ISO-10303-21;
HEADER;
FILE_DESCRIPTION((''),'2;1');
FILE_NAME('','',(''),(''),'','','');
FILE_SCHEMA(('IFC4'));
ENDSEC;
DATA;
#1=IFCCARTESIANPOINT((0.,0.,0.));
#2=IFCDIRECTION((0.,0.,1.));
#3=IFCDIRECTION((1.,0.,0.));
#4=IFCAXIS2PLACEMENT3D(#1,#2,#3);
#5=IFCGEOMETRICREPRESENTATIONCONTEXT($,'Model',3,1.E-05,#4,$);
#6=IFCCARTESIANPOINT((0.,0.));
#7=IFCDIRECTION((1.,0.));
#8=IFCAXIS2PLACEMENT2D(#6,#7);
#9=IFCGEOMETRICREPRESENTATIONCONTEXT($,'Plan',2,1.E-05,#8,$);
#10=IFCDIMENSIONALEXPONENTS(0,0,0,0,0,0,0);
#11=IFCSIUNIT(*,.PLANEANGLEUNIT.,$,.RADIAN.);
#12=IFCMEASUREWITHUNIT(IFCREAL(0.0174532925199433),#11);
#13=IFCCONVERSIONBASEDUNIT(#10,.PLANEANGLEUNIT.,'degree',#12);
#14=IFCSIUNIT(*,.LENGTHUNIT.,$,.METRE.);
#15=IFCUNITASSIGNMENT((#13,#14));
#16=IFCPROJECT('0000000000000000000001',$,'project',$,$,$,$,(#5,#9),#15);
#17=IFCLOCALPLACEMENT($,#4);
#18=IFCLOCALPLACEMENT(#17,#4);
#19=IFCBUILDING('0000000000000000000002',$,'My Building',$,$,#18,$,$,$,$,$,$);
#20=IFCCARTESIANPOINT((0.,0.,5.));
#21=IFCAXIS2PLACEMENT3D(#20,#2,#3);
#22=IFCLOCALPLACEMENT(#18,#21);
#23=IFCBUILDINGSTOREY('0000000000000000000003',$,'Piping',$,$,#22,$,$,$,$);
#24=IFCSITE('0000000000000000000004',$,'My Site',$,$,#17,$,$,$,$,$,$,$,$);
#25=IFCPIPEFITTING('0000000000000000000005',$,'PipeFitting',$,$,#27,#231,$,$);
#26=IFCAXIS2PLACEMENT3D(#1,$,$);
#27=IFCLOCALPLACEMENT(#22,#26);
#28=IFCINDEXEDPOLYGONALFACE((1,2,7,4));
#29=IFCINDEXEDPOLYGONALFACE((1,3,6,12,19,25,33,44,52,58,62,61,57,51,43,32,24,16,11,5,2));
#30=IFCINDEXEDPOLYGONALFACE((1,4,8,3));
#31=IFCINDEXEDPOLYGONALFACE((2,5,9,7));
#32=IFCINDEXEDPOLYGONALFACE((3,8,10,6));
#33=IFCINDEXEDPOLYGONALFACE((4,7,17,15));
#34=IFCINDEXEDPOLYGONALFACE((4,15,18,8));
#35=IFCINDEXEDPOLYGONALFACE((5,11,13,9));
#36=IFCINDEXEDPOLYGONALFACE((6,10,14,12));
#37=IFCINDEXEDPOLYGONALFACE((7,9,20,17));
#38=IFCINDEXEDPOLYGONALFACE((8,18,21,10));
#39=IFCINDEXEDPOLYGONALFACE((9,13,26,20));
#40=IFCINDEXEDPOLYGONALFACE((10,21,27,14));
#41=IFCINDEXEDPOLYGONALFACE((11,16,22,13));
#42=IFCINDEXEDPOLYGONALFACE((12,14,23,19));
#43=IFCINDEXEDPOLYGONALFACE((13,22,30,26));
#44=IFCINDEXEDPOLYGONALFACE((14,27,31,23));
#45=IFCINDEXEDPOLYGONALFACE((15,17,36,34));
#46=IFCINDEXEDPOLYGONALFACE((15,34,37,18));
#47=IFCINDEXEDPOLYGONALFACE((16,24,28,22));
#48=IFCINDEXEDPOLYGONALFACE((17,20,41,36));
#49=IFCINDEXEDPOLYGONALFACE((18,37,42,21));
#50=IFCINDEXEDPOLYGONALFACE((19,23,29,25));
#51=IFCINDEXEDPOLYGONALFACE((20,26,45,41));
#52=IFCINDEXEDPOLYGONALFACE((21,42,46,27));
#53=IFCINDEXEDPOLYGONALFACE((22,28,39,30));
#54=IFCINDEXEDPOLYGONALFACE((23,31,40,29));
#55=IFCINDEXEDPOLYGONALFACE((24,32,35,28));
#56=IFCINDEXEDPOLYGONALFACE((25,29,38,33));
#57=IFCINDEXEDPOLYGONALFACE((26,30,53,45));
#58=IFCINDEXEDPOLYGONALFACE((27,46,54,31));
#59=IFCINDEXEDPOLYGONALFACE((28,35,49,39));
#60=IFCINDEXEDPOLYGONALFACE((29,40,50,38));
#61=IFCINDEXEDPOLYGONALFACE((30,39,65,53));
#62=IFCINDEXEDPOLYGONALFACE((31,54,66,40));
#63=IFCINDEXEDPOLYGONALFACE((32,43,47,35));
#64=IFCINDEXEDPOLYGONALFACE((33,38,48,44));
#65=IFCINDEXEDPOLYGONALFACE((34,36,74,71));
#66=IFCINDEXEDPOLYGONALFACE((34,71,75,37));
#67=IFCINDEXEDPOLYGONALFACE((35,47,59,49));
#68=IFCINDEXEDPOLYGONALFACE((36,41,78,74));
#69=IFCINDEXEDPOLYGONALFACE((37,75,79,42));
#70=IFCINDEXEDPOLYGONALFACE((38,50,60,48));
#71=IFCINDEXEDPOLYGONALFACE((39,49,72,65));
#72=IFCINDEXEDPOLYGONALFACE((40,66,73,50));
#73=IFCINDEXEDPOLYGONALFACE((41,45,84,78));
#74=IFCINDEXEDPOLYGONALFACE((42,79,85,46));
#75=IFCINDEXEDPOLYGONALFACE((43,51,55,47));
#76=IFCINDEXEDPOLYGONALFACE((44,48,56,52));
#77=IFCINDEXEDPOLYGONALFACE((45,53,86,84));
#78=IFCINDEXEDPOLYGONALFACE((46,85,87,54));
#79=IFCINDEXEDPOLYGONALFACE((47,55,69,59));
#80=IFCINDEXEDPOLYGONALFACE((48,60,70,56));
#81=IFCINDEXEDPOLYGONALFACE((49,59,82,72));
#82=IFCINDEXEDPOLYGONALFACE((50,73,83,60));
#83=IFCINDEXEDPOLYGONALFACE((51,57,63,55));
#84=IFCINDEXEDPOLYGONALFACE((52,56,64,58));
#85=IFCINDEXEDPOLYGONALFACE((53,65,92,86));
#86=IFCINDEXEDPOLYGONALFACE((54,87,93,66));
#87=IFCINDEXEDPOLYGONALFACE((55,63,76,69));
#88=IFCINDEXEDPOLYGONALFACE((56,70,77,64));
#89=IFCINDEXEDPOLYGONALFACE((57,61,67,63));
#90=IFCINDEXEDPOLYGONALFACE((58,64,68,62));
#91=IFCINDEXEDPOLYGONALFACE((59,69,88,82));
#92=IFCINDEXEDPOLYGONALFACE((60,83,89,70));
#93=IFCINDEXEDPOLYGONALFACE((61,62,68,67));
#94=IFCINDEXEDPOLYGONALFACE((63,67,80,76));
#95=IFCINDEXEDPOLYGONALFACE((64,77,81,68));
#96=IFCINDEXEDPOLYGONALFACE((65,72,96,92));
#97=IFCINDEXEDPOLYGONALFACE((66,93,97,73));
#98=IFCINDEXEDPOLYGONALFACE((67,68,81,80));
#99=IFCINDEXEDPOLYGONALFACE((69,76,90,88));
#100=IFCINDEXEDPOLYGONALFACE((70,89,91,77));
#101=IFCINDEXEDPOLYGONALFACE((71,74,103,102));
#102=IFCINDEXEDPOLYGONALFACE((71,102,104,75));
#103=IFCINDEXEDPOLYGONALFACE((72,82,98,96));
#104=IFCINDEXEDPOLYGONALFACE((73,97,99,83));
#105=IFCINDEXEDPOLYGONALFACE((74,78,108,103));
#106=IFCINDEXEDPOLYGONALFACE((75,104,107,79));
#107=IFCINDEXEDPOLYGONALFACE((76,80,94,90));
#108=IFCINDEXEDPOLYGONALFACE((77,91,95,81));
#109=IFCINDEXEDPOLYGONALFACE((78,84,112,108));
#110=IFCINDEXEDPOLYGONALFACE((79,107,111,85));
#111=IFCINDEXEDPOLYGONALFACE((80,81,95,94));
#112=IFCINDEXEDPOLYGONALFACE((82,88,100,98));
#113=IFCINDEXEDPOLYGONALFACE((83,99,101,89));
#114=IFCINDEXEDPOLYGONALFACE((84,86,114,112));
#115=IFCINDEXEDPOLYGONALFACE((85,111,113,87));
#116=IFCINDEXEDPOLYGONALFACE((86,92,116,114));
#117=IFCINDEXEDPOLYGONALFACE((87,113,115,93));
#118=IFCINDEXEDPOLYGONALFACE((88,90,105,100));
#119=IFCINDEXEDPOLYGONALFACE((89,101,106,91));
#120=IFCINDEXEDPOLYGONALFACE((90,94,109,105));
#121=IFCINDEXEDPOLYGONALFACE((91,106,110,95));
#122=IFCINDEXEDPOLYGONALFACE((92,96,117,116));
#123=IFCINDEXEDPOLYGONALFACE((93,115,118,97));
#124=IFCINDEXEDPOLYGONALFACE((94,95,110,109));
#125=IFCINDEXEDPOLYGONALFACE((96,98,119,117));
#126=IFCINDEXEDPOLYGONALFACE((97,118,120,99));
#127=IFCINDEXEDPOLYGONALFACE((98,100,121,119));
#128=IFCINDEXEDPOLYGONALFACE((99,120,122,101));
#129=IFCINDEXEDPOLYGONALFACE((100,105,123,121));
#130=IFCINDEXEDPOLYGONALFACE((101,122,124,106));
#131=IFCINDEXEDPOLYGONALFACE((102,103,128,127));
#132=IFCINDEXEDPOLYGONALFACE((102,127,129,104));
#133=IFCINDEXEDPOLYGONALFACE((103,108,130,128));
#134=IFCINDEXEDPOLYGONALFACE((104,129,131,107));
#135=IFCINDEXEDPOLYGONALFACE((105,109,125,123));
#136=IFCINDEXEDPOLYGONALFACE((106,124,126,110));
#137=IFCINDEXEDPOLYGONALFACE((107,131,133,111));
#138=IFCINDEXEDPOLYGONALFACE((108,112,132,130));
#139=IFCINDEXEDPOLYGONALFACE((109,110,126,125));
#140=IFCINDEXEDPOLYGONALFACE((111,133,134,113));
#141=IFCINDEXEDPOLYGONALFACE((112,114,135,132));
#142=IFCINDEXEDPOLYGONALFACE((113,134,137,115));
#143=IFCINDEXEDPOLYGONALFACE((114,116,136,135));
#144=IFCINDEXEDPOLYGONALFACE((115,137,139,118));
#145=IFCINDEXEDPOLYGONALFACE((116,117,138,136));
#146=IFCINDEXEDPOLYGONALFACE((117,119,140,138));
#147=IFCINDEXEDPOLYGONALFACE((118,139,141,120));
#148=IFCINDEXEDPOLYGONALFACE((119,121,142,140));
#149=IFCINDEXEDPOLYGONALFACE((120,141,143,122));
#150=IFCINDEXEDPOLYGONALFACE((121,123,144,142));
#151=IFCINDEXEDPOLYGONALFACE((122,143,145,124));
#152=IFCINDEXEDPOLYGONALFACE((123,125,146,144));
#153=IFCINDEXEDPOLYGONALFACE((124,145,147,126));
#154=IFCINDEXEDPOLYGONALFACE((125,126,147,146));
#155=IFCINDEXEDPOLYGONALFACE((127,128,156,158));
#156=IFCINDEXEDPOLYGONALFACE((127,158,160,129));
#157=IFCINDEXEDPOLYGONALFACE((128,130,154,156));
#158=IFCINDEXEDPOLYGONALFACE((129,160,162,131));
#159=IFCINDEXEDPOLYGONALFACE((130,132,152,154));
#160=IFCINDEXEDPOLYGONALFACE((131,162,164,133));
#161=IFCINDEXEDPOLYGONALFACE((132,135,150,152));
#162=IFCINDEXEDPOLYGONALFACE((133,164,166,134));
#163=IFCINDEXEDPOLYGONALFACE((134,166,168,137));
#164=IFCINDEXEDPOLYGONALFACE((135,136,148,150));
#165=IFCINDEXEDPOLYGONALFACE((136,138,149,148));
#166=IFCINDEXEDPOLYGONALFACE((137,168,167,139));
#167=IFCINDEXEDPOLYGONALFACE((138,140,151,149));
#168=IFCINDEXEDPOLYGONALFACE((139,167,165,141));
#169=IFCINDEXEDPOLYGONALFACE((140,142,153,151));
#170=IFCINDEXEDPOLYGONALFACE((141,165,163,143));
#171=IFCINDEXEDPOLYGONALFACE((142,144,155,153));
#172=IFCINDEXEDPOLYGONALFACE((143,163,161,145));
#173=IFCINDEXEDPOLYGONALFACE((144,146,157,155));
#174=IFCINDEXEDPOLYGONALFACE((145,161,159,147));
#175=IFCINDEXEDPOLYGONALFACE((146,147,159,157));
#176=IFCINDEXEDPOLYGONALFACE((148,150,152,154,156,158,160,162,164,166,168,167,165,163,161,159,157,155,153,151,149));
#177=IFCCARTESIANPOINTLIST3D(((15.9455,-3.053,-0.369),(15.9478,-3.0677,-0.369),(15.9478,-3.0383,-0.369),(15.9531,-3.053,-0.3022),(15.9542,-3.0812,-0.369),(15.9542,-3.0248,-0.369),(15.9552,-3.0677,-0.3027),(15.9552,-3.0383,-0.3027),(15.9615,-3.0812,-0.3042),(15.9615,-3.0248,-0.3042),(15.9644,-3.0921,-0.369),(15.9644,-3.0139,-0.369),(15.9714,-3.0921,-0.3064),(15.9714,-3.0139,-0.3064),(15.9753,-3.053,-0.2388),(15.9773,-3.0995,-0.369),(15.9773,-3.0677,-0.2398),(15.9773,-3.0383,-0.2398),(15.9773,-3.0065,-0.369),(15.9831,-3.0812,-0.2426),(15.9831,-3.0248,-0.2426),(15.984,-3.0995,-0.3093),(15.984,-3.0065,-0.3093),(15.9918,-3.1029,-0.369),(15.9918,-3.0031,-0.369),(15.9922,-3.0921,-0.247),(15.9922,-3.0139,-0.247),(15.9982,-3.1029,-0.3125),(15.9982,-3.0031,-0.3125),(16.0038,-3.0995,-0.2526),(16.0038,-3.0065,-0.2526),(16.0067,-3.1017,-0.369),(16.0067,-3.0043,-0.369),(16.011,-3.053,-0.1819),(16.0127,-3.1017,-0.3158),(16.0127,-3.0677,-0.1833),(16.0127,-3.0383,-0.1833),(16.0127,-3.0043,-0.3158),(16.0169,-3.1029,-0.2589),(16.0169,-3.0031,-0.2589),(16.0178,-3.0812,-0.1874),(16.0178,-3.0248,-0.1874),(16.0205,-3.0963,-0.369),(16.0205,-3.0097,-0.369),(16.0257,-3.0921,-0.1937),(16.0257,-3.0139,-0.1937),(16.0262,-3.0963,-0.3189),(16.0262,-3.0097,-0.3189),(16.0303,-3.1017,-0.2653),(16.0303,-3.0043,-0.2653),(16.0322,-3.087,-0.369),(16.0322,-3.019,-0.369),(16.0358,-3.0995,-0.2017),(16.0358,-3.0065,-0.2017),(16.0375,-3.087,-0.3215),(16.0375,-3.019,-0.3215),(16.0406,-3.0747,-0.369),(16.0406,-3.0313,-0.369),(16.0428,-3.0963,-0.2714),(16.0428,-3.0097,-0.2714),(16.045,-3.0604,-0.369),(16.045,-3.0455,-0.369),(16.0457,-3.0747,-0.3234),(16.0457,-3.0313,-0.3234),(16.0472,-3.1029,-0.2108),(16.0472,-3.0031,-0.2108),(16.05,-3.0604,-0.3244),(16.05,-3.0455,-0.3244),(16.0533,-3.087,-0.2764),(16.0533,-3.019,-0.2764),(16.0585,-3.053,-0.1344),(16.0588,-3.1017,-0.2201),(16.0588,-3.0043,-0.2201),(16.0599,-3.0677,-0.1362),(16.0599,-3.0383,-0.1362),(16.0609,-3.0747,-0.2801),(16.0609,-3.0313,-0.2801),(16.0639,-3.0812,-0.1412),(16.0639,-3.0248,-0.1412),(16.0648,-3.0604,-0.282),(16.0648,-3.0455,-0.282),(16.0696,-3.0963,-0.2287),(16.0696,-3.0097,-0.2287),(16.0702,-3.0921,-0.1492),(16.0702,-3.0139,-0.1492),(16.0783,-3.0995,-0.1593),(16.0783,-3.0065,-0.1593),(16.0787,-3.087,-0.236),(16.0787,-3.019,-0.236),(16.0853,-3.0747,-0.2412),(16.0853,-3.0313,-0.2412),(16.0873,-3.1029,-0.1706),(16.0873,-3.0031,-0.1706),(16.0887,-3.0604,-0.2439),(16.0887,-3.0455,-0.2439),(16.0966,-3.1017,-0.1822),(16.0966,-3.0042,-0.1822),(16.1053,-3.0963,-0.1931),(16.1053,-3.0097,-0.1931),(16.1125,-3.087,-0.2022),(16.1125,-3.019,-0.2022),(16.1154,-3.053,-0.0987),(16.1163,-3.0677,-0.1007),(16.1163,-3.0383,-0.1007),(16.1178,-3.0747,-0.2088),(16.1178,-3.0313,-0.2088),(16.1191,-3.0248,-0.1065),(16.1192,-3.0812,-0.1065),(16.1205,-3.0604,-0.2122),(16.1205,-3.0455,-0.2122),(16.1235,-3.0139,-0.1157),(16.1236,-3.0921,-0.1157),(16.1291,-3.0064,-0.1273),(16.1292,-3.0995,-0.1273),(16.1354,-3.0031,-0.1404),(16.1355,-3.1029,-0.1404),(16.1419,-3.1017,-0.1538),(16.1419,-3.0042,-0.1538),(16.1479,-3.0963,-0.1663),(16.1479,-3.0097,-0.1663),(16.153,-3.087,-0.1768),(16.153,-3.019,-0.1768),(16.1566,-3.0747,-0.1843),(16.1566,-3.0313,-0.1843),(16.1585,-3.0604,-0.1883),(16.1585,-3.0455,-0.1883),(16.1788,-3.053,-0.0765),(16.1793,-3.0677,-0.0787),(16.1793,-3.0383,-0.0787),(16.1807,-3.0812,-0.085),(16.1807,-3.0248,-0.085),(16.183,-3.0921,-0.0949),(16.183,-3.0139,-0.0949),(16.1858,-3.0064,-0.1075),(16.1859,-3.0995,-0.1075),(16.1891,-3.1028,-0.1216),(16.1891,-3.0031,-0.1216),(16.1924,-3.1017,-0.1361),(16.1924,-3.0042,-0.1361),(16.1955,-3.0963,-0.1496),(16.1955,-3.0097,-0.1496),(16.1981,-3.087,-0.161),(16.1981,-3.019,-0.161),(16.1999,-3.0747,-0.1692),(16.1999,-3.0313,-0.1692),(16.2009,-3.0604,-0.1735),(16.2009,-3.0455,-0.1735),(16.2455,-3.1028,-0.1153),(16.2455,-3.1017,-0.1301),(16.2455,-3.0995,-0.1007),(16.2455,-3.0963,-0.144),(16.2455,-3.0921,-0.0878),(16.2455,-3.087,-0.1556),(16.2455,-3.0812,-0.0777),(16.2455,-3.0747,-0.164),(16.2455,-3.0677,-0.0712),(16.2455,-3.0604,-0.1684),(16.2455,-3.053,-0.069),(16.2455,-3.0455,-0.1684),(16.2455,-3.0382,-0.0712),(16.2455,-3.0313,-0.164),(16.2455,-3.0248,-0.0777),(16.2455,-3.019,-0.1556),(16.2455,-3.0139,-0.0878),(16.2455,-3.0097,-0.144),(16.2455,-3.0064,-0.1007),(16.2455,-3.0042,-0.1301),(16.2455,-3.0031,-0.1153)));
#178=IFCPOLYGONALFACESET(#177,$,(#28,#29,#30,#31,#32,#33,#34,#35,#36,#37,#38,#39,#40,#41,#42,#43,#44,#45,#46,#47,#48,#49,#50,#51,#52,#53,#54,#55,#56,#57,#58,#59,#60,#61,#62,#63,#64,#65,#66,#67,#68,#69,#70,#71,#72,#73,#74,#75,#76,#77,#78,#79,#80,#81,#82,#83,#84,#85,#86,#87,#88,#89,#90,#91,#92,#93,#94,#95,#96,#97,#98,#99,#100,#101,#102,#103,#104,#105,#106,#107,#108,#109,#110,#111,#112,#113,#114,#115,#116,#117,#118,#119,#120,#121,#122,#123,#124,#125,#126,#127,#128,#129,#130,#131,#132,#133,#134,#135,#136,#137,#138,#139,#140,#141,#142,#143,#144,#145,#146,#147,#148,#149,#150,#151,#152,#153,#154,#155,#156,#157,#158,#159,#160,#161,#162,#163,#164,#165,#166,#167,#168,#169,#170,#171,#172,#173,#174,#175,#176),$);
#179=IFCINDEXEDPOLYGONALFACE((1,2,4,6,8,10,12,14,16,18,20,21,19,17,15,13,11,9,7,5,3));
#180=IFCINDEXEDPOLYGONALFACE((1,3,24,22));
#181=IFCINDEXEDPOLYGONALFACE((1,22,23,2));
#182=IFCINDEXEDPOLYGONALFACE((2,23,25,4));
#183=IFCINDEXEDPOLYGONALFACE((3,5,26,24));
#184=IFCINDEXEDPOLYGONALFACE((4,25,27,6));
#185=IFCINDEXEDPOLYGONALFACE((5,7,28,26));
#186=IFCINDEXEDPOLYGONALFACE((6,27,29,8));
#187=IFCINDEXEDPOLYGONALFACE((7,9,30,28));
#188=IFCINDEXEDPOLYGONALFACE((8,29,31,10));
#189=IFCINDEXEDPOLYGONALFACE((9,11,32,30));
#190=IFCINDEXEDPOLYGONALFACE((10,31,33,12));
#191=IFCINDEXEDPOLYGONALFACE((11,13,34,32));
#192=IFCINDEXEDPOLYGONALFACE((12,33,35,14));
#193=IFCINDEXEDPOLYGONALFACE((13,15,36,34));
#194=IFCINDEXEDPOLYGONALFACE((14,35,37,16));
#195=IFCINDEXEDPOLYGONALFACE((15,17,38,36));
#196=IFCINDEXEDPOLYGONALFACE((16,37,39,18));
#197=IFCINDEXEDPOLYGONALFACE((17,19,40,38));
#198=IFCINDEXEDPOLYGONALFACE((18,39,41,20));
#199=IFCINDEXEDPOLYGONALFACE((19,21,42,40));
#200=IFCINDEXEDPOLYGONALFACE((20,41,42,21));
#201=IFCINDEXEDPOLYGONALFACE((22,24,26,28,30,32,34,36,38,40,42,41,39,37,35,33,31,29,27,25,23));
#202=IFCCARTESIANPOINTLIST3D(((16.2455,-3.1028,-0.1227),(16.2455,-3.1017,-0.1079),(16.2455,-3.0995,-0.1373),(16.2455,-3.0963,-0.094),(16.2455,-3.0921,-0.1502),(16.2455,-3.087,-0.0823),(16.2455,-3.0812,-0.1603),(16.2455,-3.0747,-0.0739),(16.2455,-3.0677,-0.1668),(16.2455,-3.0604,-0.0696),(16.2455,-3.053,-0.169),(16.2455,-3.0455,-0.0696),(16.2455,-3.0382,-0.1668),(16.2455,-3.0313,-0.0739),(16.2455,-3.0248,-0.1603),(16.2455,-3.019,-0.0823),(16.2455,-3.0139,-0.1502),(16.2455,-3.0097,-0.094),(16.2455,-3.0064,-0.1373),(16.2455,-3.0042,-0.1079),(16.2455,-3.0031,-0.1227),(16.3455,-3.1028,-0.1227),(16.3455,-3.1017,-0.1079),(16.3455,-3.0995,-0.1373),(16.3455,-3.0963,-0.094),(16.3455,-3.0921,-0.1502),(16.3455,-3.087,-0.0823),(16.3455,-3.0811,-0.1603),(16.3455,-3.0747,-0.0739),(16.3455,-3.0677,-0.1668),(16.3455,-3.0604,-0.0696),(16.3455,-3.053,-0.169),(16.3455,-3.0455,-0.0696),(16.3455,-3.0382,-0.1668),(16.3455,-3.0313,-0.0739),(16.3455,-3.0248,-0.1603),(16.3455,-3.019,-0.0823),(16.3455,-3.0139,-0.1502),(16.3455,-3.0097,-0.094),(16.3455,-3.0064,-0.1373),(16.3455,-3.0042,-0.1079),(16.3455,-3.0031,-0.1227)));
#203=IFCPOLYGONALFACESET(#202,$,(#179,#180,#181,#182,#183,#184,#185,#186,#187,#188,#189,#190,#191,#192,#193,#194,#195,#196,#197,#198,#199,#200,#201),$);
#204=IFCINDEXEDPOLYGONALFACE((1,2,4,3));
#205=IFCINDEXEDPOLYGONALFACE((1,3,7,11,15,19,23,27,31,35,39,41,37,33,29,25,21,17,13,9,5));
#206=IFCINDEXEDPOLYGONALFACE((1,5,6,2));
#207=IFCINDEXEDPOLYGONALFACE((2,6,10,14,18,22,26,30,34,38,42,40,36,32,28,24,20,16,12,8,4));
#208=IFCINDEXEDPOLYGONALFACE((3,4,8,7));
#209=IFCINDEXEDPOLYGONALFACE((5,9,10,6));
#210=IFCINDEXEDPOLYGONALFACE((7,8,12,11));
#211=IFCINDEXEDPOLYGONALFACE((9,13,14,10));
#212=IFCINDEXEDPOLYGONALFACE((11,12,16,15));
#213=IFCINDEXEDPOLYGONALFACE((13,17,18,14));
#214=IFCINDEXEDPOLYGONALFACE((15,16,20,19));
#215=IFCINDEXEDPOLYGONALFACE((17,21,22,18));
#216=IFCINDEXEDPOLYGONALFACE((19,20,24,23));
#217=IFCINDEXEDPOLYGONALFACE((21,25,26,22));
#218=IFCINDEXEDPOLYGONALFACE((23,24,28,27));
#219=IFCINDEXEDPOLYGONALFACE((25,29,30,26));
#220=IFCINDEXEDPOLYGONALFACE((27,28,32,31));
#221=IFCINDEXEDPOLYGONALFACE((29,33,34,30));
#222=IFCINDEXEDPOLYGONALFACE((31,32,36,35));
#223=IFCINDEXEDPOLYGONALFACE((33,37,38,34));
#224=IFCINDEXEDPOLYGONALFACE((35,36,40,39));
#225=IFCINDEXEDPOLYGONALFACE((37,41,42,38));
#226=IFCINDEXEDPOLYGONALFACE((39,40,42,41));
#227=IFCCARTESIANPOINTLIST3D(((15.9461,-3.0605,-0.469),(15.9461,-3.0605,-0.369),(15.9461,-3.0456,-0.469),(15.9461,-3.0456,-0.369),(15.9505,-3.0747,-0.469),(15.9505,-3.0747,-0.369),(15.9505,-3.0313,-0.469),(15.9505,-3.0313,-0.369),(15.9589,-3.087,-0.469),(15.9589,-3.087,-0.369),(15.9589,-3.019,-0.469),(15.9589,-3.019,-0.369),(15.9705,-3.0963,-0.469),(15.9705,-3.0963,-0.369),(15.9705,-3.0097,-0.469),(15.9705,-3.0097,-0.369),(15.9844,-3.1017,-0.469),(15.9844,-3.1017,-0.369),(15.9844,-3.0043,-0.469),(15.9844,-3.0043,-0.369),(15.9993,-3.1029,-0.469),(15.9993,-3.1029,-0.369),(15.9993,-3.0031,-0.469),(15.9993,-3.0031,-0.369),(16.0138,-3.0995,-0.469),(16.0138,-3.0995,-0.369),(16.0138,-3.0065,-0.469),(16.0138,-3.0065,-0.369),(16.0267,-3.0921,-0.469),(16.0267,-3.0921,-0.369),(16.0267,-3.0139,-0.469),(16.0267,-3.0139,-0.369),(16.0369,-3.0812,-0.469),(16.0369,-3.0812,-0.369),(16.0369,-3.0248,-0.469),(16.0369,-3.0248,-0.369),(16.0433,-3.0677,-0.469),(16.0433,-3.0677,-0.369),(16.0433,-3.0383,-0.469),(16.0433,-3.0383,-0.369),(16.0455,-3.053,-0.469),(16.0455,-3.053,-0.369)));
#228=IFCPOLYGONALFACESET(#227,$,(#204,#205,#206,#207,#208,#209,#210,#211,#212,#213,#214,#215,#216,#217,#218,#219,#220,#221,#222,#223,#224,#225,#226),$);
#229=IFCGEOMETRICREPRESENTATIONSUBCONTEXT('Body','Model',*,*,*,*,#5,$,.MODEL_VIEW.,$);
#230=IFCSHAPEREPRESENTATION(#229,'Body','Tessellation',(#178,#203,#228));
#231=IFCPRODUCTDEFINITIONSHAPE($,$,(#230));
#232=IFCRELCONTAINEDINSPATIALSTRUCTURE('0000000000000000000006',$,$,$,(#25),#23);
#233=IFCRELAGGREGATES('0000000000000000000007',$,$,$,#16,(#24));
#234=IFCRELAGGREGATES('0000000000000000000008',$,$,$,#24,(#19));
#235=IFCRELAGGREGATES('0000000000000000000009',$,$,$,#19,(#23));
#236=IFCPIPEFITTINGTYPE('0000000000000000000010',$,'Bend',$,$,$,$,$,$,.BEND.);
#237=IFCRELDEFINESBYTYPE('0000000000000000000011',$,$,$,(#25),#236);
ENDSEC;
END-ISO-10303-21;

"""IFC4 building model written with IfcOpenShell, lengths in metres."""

from ifc_helpers import new_model, entity, si_unit, converted_unit, frame, origin_with_axes, origin_2d_with_axis, place, context, subcontext, project, spatial, circle, extrude, source, transform, mapped, type_object, type_shapes, element, save


model = new_model("IFC4")

# Units and contexts
model_context = context("Model", 3, precision=1e-05, world=origin_with_axes())
plan_context = context("Plan", 2, precision=1e-05, world=origin_2d_with_axis())
body_context = subcontext(model_context, "Body", "Model", "MODEL_VIEW")
ifc_project = project(units=[converted_unit("PLANEANGLEUNIT", "degree", entity("IfcReal", 0.0174532925199433), si_unit("PLANEANGLEUNIT", "RADIAN"), dimensions=[0, 0, 0, 0, 0, 0, 0]), si_unit("LENGTHUNIT", "METRE")], contexts=[model_context, plan_context])

# Site, building, storey
site_placement = place(None, origin_with_axes())
site = spatial("IfcSite", under=ifc_project, at=site_placement, Name="My Site")
building_placement = place(site_placement, origin_with_axes())
building = spatial("IfcBuilding", under=site, at=building_placement, Name="My Building")
storey_placement = place(building_placement, frame((0.0, 0.0, 5.0), z_axis=(0.0, 0.0, 1.0), x_axis=(1.0, 0.0, 0.0)))
storey = spatial("IfcBuildingStorey", under=building, at=storey_placement, Name="Piping")

# Pipe fitting
pipe_fitting_type_1 = type_object("IfcPipeFittingType", Name="Bend", PredefinedType="BEND")
shared_shape = source(origin_with_axes(), body_context, "Body", "SolidModel", [
    entity("IfcSweptDiskSolid", entity("IfcIndexedPolyCurve", entity("IfcCartesianPointList3D", [[0.0, 0.0, -0.1], [0.0732, 0.0, -0.2768], [0.25, 0.0, -0.35]]), [entity("IfcArcIndex", [1, 2, 3])]), 0.05),
    extrude(circle(Radius=0.05), origin_with_axes(), (0.0, 0.0, -1.0), 0.1),
    extrude(circle(Radius=0.05), frame((0.25, 0.0, -0.35), z_axis=(1.0, 0.0, 0.0), x_axis=(0.0, 0.0, 1.0)), (0.0, 0.0, 1.0), 0.1),
])
type_shapes(pipe_fitting_type_1, [shared_shape])
for number, where, z_axis, x_axis, name in (
    (1, (16.3455, -3.053, -0.119), (1.0, 0.00006, 0.0), (0.0, 0.0, -1.0), "PipeFitting"),
):
    element("IfcPipeFitting", number, at=place(storey_placement, frame(where, z_axis=z_axis, x_axis=x_axis)), inside=storey, type_object=pipe_fitting_type_1, Name=name, context=body_context, shape_type="MappedRepresentation", body=[
        mapped(shared_shape, transform((0.0, 0.0, 0.0), x_axis=(1.0, 0.0, 0.0), y_axis=(0.0, 1.0, 0.0), z_axis=(0.0, 0.0, 1.0), scale=1.0)),
    ])

save(model, "model.ifc")
